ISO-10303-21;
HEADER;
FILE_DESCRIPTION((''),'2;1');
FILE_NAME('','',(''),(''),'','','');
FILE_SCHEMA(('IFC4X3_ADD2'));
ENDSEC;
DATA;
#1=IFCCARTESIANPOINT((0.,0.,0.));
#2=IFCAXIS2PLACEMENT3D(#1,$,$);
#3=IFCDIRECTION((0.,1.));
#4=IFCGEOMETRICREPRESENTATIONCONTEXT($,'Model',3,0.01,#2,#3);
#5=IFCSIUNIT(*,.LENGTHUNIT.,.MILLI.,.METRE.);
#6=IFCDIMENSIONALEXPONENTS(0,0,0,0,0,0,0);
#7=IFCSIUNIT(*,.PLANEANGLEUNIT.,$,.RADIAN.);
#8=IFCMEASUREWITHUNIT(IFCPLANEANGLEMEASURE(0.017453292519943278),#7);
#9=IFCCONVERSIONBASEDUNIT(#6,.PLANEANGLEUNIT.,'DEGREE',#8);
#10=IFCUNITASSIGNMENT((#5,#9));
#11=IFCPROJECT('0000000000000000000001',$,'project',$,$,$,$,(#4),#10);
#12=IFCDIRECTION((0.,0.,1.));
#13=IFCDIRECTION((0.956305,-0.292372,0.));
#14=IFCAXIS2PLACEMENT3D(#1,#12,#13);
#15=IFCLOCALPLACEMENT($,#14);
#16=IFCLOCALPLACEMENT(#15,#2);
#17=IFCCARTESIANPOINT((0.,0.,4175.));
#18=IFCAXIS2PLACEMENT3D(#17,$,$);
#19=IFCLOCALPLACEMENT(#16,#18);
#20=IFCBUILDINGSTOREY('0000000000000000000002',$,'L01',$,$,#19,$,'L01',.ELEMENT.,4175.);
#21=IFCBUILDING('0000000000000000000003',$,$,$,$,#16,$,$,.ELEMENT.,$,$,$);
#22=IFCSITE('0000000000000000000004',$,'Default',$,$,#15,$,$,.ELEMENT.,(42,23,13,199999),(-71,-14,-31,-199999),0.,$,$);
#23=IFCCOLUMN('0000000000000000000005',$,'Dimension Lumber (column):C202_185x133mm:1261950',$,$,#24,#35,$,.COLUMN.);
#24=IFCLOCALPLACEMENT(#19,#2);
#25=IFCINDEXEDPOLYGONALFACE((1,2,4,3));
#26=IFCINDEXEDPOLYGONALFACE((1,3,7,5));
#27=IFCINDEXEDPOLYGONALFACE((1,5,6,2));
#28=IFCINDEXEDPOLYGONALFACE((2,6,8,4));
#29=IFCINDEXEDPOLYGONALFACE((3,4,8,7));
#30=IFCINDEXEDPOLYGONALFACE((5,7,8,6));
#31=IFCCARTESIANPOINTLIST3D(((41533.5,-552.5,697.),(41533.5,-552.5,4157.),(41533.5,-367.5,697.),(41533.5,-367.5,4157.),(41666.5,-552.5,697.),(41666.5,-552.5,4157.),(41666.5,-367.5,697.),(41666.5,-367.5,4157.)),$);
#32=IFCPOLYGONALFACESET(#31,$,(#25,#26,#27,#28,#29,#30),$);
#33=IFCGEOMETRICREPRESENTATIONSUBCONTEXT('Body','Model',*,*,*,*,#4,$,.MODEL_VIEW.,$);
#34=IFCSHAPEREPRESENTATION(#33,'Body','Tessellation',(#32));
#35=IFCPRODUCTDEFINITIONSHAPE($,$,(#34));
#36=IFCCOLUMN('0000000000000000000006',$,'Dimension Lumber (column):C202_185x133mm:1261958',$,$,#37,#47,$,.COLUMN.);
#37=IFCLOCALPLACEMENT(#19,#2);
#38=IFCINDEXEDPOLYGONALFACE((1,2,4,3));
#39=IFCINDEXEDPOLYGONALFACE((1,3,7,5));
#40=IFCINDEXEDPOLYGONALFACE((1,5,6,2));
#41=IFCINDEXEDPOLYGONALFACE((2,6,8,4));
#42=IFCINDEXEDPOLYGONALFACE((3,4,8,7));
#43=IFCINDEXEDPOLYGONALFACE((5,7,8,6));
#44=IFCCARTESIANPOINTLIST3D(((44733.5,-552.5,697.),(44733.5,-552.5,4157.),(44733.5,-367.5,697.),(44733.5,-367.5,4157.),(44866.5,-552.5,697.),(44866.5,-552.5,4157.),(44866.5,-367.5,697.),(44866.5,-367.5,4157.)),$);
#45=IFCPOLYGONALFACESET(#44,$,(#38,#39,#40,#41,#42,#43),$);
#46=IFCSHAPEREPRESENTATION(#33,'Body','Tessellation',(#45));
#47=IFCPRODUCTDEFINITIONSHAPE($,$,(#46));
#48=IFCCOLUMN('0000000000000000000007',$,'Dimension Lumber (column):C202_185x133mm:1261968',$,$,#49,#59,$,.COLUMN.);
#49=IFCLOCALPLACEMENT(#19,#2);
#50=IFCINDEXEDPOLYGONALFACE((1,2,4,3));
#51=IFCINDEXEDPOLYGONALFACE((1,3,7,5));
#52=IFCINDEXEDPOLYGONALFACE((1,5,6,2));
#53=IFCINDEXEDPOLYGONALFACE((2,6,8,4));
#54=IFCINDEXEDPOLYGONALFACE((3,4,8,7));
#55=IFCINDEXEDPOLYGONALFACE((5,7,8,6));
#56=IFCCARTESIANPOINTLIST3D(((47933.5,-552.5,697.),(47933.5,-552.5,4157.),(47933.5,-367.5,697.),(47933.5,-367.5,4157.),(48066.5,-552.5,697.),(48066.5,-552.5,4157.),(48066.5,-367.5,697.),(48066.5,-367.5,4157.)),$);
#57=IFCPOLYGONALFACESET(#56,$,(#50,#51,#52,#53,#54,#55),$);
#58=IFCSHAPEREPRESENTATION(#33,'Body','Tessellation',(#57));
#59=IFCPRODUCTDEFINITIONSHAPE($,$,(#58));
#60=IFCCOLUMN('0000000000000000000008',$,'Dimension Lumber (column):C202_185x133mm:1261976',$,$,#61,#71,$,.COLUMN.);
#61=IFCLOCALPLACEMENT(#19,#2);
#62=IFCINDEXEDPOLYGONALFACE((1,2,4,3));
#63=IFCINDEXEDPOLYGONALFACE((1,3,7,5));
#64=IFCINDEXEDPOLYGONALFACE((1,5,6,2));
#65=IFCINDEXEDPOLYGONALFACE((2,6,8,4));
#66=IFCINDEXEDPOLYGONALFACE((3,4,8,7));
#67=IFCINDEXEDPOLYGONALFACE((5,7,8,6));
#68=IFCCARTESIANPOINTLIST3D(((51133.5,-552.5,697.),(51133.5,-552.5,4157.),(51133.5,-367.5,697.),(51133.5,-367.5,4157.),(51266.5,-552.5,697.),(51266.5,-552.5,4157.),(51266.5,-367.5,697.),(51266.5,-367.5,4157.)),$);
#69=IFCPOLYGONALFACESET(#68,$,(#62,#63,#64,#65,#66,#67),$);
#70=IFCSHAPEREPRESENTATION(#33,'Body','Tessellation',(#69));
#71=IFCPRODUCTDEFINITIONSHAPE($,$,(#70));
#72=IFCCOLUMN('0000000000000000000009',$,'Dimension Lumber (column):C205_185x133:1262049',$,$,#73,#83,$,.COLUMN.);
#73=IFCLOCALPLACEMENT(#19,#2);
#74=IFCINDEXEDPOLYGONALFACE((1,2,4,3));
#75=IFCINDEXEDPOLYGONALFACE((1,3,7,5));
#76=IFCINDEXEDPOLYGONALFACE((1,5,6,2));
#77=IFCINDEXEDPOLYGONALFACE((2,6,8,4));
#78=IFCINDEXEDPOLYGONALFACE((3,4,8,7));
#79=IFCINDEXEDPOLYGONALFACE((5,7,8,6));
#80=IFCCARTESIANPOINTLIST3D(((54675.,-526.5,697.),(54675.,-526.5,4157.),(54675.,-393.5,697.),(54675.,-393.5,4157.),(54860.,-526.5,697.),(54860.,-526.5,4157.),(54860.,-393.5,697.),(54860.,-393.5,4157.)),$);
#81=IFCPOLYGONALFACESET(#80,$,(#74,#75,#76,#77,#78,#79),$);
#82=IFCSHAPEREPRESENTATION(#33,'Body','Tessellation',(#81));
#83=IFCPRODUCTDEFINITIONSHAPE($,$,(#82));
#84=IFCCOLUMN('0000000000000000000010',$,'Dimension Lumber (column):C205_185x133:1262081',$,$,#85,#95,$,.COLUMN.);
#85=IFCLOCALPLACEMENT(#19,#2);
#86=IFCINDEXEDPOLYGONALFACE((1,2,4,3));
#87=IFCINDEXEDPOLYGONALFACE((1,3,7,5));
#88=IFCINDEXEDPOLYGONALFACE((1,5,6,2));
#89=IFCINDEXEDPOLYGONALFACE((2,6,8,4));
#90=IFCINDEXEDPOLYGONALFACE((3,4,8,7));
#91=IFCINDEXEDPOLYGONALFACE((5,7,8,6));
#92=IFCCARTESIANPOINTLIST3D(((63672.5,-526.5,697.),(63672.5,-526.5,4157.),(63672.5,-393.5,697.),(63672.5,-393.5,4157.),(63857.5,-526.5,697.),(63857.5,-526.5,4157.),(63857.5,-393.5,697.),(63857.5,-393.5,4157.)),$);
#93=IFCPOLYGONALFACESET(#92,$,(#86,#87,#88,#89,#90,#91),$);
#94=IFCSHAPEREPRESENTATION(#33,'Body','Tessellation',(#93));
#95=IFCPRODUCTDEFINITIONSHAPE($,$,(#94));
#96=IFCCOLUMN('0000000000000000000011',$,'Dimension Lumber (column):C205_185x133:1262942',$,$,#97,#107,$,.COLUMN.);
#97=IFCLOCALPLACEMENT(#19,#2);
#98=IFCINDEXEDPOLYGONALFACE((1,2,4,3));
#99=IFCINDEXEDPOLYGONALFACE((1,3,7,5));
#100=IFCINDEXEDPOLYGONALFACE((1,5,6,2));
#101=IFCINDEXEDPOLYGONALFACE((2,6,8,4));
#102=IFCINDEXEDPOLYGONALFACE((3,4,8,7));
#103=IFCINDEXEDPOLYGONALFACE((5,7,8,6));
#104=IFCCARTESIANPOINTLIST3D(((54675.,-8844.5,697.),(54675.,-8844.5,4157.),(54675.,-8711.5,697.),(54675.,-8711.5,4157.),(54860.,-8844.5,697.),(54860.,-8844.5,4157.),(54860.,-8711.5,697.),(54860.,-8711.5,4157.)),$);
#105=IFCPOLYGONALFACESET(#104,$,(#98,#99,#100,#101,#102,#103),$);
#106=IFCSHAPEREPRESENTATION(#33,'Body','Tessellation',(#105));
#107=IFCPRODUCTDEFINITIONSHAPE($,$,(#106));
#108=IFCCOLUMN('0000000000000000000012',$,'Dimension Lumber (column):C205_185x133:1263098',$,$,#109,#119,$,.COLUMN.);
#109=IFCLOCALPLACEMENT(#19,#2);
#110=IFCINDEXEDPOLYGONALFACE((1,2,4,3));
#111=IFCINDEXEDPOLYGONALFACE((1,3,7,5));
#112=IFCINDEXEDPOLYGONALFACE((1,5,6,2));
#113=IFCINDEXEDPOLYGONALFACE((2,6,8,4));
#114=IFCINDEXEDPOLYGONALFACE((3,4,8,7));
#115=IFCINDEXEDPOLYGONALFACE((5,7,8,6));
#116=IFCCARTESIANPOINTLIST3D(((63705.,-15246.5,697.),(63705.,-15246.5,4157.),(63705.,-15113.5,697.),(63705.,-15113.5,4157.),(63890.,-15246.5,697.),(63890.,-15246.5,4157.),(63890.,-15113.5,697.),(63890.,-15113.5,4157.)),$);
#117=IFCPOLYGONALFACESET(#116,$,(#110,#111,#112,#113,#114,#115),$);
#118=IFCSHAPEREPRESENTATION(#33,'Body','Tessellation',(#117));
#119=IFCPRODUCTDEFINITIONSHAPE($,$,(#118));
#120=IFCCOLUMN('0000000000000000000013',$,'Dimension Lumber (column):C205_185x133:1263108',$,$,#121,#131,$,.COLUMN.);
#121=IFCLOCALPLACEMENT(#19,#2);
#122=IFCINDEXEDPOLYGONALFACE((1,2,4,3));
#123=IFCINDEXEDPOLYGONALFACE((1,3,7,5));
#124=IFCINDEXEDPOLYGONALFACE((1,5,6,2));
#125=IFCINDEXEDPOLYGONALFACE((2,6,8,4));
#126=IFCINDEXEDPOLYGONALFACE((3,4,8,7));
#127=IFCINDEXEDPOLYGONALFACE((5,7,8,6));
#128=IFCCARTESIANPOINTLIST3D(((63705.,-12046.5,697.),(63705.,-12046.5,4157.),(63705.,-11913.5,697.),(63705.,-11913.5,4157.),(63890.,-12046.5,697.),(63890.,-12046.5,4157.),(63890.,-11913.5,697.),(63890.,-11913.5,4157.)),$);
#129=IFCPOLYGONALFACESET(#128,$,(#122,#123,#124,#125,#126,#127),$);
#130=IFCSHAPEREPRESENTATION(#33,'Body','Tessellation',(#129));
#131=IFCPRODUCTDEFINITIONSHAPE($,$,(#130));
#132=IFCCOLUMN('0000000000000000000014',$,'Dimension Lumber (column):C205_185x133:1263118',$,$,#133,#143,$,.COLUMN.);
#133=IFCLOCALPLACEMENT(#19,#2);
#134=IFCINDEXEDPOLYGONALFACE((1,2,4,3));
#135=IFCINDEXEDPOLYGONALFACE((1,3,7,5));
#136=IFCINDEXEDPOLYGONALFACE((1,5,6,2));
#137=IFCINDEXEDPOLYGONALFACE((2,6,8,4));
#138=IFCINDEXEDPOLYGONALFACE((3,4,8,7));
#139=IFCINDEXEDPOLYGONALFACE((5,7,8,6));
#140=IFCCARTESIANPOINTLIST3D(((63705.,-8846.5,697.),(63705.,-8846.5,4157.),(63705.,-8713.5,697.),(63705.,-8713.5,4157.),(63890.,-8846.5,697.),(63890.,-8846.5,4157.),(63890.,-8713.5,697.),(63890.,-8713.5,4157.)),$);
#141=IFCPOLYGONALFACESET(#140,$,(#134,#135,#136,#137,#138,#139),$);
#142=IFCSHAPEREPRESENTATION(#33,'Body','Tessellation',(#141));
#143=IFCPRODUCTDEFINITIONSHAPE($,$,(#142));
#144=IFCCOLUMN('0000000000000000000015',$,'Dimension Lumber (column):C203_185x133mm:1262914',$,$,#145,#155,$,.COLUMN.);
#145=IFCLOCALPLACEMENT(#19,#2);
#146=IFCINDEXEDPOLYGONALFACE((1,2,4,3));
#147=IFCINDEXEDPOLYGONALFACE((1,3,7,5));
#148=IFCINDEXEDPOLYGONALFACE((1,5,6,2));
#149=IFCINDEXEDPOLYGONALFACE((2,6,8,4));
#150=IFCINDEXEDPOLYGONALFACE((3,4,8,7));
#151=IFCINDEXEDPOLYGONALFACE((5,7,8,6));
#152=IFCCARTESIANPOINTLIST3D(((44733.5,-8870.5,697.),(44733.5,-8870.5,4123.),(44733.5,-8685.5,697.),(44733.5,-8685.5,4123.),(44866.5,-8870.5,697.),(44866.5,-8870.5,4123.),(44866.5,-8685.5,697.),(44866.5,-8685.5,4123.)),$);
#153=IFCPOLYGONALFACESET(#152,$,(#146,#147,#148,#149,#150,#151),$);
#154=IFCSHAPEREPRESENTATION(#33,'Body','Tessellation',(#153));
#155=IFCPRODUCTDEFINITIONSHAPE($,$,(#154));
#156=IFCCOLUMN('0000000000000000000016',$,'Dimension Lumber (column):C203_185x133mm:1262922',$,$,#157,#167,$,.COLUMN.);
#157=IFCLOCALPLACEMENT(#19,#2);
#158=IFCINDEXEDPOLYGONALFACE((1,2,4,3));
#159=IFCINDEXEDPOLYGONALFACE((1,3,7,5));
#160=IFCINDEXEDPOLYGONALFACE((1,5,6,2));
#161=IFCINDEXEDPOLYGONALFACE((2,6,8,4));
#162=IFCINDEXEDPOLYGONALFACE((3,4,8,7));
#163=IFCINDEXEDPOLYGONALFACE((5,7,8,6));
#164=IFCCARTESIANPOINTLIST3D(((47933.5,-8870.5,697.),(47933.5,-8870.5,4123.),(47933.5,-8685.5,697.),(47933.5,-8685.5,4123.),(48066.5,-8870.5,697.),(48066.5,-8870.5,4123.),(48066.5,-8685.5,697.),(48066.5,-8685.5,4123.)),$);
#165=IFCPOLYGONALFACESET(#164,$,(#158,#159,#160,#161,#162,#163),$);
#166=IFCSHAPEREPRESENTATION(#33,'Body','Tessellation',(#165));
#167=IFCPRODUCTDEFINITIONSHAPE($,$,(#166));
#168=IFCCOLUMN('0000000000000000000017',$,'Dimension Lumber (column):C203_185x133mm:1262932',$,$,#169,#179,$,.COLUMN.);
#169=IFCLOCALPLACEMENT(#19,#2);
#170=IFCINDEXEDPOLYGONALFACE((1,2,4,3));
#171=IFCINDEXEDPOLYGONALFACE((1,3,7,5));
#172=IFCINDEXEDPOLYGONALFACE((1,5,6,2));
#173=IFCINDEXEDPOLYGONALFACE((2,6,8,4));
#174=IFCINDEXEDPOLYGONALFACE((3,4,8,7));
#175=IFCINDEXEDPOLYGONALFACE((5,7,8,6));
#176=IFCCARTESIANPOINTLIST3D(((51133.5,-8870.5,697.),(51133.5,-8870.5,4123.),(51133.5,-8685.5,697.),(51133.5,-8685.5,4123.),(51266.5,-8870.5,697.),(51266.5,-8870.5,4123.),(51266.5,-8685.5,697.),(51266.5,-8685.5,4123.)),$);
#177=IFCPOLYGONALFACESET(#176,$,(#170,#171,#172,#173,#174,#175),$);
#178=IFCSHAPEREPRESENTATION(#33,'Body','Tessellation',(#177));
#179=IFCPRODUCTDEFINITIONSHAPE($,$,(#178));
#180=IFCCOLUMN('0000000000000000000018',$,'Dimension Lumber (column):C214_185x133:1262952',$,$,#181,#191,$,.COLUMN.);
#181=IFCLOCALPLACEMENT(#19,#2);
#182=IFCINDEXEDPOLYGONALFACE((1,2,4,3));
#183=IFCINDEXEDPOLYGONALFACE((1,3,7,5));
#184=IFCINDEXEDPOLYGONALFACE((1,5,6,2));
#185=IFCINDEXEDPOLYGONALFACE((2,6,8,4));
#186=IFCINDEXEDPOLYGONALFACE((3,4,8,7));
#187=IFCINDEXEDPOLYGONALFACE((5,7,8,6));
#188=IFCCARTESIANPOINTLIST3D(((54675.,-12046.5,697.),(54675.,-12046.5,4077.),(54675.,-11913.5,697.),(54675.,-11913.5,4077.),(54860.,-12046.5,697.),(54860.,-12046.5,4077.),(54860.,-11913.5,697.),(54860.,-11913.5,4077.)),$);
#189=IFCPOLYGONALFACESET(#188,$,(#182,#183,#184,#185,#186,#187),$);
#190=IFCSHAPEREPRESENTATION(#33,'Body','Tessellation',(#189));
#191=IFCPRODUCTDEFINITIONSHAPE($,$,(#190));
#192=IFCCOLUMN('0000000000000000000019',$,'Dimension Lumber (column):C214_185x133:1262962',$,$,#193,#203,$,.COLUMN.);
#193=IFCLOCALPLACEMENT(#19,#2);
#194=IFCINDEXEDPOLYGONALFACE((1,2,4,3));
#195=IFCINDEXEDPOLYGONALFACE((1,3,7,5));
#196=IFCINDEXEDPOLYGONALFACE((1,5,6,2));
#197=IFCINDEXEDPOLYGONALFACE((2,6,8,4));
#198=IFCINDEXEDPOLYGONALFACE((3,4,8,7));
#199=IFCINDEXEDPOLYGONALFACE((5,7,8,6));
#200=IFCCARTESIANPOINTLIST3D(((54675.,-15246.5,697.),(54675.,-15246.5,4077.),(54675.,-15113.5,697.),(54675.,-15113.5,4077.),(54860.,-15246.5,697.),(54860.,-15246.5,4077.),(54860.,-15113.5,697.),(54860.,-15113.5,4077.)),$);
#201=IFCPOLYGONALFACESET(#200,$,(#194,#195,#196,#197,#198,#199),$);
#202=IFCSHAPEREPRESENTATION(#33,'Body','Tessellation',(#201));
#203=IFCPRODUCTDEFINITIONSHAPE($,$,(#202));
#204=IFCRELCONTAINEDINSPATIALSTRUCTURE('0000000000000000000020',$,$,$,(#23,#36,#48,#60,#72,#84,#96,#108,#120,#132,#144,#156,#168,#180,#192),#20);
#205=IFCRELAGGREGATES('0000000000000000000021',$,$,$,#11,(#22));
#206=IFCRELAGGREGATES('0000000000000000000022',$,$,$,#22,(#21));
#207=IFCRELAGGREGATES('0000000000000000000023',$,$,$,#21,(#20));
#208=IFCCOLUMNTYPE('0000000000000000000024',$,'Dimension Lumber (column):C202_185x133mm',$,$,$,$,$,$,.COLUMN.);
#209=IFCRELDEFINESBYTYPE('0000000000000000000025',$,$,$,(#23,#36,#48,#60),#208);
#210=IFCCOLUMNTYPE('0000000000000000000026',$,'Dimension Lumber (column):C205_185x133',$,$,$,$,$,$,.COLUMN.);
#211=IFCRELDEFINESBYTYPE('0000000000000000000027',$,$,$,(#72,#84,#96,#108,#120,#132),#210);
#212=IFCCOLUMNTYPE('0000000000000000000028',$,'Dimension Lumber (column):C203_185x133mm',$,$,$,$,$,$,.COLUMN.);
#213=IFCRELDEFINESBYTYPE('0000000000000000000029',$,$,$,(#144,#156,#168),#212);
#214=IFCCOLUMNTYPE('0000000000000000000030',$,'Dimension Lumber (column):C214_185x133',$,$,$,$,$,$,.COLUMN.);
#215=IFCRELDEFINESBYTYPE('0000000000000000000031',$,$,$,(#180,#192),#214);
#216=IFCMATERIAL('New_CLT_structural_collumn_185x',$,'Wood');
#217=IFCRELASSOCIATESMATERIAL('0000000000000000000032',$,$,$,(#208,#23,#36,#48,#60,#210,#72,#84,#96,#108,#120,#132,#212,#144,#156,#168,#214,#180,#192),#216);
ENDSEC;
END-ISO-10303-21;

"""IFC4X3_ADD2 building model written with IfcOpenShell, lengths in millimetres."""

from ifc_helpers import new_model, entity, si_unit, converted_unit, direction, frame, origin, origin_2d_with_axis, place, context, subcontext, project, spatial, rectangle, extrude, source, transform, mapped, material, material_profile, profile_set, profile_usage, type_object, type_shapes, element, save


model = new_model("IFC4X3_ADD2")

# Units and contexts
model_context = context("Model", 3, precision=0.01, world=origin(), true_north=direction((0.0, 1.0)))
body_context = subcontext(model_context, "Body", "Model", "MODEL_VIEW")
ifc_project = project(units=[si_unit("LENGTHUNIT", "METRE", prefix="MILLI"), converted_unit("PLANEANGLEUNIT", "DEGREE", entity("IfcPlaneAngleMeasure", 0.017453292519943278), si_unit("PLANEANGLEUNIT", "RADIAN"), dimensions=[0, 0, 0, 0, 0, 0, 0])], contexts=[model_context])

# Site, building, storey
site_placement = place(None, frame((0.0, 0.0, 0.0), z_axis=(0.0, 0.0, 1.0), x_axis=(0.956305, -0.292372, 0.0)))
site = spatial("IfcSite", under=ifc_project, at=site_placement, Name="Default", CompositionType="ELEMENT", RefLatitude=(42, 23, 13, 199999), RefLongitude=(-71, -14, -31, -199999), RefElevation=0.0)
building_placement = place(site_placement, origin())
building = spatial("IfcBuilding", under=site, at=building_placement, CompositionType="ELEMENT")
storey_placement = place(building_placement, frame((0.0, 0.0, 4175.0)))
storey = spatial("IfcBuildingStorey", under=building, at=storey_placement, Name="L01", LongName="L01", CompositionType="ELEMENT", Elevation=4175.0)

# Columns
ifc_material_1 = material(Name="New_CLT_structural_collumn_185x", Category="Wood")
ifc_material_profile_1 = material_profile(ifc_material_1, rectangle(XDim=185.0, YDim=133.0, at=origin_2d_with_axis()), Name="C202_185x133mm")
ifc_profile_set_1 = profile_set([ifc_material_profile_1], Name="C202_185x133mm")
ifc_profile_usage_1 = profile_usage(ifc_profile_set_1)
column_type_1 = type_object("IfcColumnType", Name="Dimension Lumber (column):C202_185x133mm", PredefinedType="COLUMN", material=ifc_profile_set_1)
shared_shape_1 = source(origin(), body_context, "Body", "SweptSolid", [
    extrude(rectangle(XDim=185.0, YDim=133.0, at=origin_2d_with_axis()), frame((0.0, 0.0, 4872.0), z_axis=(0.0, 0.0, 1.0), x_axis=(-1.0, 0.0, 0.0)), (0.0, 0.0, 1.0), 3460.0),
])
type_shapes(column_type_1, [shared_shape_1])
for number, where, z_axis, x_axis, name in (
    (1, (41600.0, -460.0, -4175.0), (0.0, 0.0, 1.0), (0.0, 1.0, 0.0), "Dimension Lumber (column):C202_185x133mm:1261950"),
    (2, (44800.0, -460.0, -4175.0), (0.0, 0.0, 1.0), (0.0, 1.0, 0.0), "Dimension Lumber (column):C202_185x133mm:1261958"),
    (3, (48000.0, -460.0, -4175.0), (0.0, 0.0, 1.0), (0.0, 1.0, 0.0), "Dimension Lumber (column):C202_185x133mm:1261968"),
    (4, (51200.0, -460.0, -4175.0), (0.0, 0.0, 1.0), (0.0, 1.0, 0.0), "Dimension Lumber (column):C202_185x133mm:1261976"),
):
    element("IfcColumn", number, at=place(storey_placement, frame(where, z_axis=z_axis, x_axis=x_axis)), inside=storey, type_object=column_type_1, material=ifc_profile_usage_1, Name=name, PredefinedType="COLUMN", context=body_context, shape_type="MappedRepresentation", body=[
        mapped(shared_shape_1, transform((0.0, 0.0, 0.0), scale=1.0)),
    ])
ifc_material_profile_2 = material_profile(ifc_material_1, rectangle(XDim=185.0, YDim=133.0, at=origin_2d_with_axis()), Name="C205_185x133")
ifc_profile_set_2 = profile_set([ifc_material_profile_2], Name="C205_185x133")
ifc_profile_usage_2 = profile_usage(ifc_profile_set_2)
column_type_2 = type_object("IfcColumnType", Name="Dimension Lumber (column):C205_185x133", PredefinedType="COLUMN", material=ifc_profile_set_2)
shared_shape_2 = source(origin(), body_context, "Body", "SweptSolid", [
    extrude(rectangle(XDim=185.0, YDim=133.0, at=origin_2d_with_axis()), frame((0.0, 0.0, 4872.0), z_axis=(0.0, 0.0, 1.0), x_axis=(-1.0, 0.0, 0.0)), (0.0, 0.0, 1.0), 3460.0),
])
type_shapes(column_type_2, [shared_shape_2])
column_1_placement = place(storey_placement, frame((54767.5, -460.0, -4175.0), z_axis=(0.0, 0.0, 1.0), x_axis=(-1.0, 0.0, 0.0)))
element("IfcColumn", 5, at=column_1_placement, inside=storey, type_object=column_type_2, material=ifc_profile_usage_2, Name="Dimension Lumber (column):C205_185x133:1262049", PredefinedType="COLUMN", context=body_context, shape_type="MappedRepresentation", body=[
    mapped(shared_shape_2, transform((0.0, 0.0, 0.0), scale=1.0)),
])
column_2_placement = place(storey_placement, frame((63765.0, -460.0, -4175.0)))
element("IfcColumn", 6, at=column_2_placement, inside=storey, type_object=column_type_2, material=ifc_profile_usage_2, Name="Dimension Lumber (column):C205_185x133:1262081", PredefinedType="COLUMN", context=body_context, shape_type="MappedRepresentation", body=[
    mapped(shared_shape_2, transform((0.0, 0.0, 0.0), scale=1.0)),
])
column_3_placement = place(storey_placement, frame((54767.5, -8778.0, -4175.0), z_axis=(0.0, 0.0, 1.0), x_axis=(-1.0, 0.0, 0.0)))
element("IfcColumn", 7, at=column_3_placement, inside=storey, type_object=column_type_2, material=ifc_profile_usage_2, Name="Dimension Lumber (column):C205_185x133:1262942", PredefinedType="COLUMN", context=body_context, shape_type="MappedRepresentation", body=[
    mapped(shared_shape_2, transform((0.0, 0.0, 0.0), scale=1.0)),
])
for number, where, name in (
    (8, (63797.5, -15180.0, -4175.0), "Dimension Lumber (column):C205_185x133:1263098"),
    (9, (63797.5, -11980.0, -4175.0), "Dimension Lumber (column):C205_185x133:1263108"),
    (10, (63797.5, -8780.0, -4175.0), "Dimension Lumber (column):C205_185x133:1263118"),
):
    element("IfcColumn", number, at=place(storey_placement, frame(where)), inside=storey, type_object=column_type_2, material=ifc_profile_usage_2, Name=name, PredefinedType="COLUMN", context=body_context, shape_type="MappedRepresentation", body=[
        mapped(shared_shape_2, transform((0.0, 0.0, 0.0), scale=1.0)),
    ])
ifc_material_profile_3 = material_profile(ifc_material_1, rectangle(XDim=185.0, YDim=133.0, at=origin_2d_with_axis()), Name="C203_185x133mm")
ifc_profile_set_3 = profile_set([ifc_material_profile_3], Name="C203_185x133mm")
ifc_profile_usage_3 = profile_usage(ifc_profile_set_3)
column_type_3 = type_object("IfcColumnType", Name="Dimension Lumber (column):C203_185x133mm", PredefinedType="COLUMN", material=ifc_profile_set_3)
shared_shape_3 = source(origin(), body_context, "Body", "SweptSolid", [
    extrude(rectangle(XDim=185.0, YDim=133.0, at=origin_2d_with_axis()), frame((0.0, 0.0, 4872.0), z_axis=(0.0, 0.0, 1.0), x_axis=(-1.0, 0.0, 0.0)), (0.0, 0.0, 1.0), 3426.0),
])
type_shapes(column_type_3, [shared_shape_3])
for number, where, z_axis, x_axis, name in (
    (11, (44800.0, -8778.0, -4175.0), (0.0, 0.0, 1.0), (0.0, 1.0, 0.0), "Dimension Lumber (column):C203_185x133mm:1262914"),
    (12, (48000.0, -8778.0, -4175.0), (0.0, 0.0, 1.0), (0.0, 1.0, 0.0), "Dimension Lumber (column):C203_185x133mm:1262922"),
    (13, (51200.0, -8778.0, -4175.0), (0.0, 0.0, 1.0), (0.0, 1.0, 0.0), "Dimension Lumber (column):C203_185x133mm:1262932"),
):
    element("IfcColumn", number, at=place(storey_placement, frame(where, z_axis=z_axis, x_axis=x_axis)), inside=storey, type_object=column_type_3, material=ifc_profile_usage_3, Name=name, PredefinedType="COLUMN", context=body_context, shape_type="MappedRepresentation", body=[
        mapped(shared_shape_3, transform((0.0, 0.0, 0.0), scale=1.0)),
    ])
ifc_material_profile_4 = material_profile(ifc_material_1, rectangle(XDim=185.0, YDim=133.0, at=origin_2d_with_axis()), Name="C214_185x133")
ifc_profile_set_4 = profile_set([ifc_material_profile_4], Name="C214_185x133")
ifc_profile_usage_4 = profile_usage(ifc_profile_set_4)
column_type_4 = type_object("IfcColumnType", Name="Dimension Lumber (column):C214_185x133", PredefinedType="COLUMN", material=ifc_profile_set_4)
shared_shape_4 = source(origin(), body_context, "Body", "SweptSolid", [
    extrude(rectangle(XDim=185.0, YDim=133.0, at=origin_2d_with_axis()), frame((0.0, 0.0, 4872.0), z_axis=(0.0, 0.0, 1.0), x_axis=(-1.0, 0.0, 0.0)), (0.0, 0.0, 1.0), 3380.0),
])
type_shapes(column_type_4, [shared_shape_4])
for number, where, name in (
    (14, (54767.5, -11980.0, -4175.0), "Dimension Lumber (column):C214_185x133:1262952"),
    (15, (54767.5, -15180.0, -4175.0), "Dimension Lumber (column):C214_185x133:1262962"),
):
    element("IfcColumn", number, at=place(storey_placement, frame(where)), inside=storey, type_object=column_type_4, material=ifc_profile_usage_4, Name=name, PredefinedType="COLUMN", context=body_context, shape_type="MappedRepresentation", body=[
        mapped(shared_shape_4, transform((0.0, 0.0, 0.0), scale=1.0)),
    ])

save(model, "model.ifc")
